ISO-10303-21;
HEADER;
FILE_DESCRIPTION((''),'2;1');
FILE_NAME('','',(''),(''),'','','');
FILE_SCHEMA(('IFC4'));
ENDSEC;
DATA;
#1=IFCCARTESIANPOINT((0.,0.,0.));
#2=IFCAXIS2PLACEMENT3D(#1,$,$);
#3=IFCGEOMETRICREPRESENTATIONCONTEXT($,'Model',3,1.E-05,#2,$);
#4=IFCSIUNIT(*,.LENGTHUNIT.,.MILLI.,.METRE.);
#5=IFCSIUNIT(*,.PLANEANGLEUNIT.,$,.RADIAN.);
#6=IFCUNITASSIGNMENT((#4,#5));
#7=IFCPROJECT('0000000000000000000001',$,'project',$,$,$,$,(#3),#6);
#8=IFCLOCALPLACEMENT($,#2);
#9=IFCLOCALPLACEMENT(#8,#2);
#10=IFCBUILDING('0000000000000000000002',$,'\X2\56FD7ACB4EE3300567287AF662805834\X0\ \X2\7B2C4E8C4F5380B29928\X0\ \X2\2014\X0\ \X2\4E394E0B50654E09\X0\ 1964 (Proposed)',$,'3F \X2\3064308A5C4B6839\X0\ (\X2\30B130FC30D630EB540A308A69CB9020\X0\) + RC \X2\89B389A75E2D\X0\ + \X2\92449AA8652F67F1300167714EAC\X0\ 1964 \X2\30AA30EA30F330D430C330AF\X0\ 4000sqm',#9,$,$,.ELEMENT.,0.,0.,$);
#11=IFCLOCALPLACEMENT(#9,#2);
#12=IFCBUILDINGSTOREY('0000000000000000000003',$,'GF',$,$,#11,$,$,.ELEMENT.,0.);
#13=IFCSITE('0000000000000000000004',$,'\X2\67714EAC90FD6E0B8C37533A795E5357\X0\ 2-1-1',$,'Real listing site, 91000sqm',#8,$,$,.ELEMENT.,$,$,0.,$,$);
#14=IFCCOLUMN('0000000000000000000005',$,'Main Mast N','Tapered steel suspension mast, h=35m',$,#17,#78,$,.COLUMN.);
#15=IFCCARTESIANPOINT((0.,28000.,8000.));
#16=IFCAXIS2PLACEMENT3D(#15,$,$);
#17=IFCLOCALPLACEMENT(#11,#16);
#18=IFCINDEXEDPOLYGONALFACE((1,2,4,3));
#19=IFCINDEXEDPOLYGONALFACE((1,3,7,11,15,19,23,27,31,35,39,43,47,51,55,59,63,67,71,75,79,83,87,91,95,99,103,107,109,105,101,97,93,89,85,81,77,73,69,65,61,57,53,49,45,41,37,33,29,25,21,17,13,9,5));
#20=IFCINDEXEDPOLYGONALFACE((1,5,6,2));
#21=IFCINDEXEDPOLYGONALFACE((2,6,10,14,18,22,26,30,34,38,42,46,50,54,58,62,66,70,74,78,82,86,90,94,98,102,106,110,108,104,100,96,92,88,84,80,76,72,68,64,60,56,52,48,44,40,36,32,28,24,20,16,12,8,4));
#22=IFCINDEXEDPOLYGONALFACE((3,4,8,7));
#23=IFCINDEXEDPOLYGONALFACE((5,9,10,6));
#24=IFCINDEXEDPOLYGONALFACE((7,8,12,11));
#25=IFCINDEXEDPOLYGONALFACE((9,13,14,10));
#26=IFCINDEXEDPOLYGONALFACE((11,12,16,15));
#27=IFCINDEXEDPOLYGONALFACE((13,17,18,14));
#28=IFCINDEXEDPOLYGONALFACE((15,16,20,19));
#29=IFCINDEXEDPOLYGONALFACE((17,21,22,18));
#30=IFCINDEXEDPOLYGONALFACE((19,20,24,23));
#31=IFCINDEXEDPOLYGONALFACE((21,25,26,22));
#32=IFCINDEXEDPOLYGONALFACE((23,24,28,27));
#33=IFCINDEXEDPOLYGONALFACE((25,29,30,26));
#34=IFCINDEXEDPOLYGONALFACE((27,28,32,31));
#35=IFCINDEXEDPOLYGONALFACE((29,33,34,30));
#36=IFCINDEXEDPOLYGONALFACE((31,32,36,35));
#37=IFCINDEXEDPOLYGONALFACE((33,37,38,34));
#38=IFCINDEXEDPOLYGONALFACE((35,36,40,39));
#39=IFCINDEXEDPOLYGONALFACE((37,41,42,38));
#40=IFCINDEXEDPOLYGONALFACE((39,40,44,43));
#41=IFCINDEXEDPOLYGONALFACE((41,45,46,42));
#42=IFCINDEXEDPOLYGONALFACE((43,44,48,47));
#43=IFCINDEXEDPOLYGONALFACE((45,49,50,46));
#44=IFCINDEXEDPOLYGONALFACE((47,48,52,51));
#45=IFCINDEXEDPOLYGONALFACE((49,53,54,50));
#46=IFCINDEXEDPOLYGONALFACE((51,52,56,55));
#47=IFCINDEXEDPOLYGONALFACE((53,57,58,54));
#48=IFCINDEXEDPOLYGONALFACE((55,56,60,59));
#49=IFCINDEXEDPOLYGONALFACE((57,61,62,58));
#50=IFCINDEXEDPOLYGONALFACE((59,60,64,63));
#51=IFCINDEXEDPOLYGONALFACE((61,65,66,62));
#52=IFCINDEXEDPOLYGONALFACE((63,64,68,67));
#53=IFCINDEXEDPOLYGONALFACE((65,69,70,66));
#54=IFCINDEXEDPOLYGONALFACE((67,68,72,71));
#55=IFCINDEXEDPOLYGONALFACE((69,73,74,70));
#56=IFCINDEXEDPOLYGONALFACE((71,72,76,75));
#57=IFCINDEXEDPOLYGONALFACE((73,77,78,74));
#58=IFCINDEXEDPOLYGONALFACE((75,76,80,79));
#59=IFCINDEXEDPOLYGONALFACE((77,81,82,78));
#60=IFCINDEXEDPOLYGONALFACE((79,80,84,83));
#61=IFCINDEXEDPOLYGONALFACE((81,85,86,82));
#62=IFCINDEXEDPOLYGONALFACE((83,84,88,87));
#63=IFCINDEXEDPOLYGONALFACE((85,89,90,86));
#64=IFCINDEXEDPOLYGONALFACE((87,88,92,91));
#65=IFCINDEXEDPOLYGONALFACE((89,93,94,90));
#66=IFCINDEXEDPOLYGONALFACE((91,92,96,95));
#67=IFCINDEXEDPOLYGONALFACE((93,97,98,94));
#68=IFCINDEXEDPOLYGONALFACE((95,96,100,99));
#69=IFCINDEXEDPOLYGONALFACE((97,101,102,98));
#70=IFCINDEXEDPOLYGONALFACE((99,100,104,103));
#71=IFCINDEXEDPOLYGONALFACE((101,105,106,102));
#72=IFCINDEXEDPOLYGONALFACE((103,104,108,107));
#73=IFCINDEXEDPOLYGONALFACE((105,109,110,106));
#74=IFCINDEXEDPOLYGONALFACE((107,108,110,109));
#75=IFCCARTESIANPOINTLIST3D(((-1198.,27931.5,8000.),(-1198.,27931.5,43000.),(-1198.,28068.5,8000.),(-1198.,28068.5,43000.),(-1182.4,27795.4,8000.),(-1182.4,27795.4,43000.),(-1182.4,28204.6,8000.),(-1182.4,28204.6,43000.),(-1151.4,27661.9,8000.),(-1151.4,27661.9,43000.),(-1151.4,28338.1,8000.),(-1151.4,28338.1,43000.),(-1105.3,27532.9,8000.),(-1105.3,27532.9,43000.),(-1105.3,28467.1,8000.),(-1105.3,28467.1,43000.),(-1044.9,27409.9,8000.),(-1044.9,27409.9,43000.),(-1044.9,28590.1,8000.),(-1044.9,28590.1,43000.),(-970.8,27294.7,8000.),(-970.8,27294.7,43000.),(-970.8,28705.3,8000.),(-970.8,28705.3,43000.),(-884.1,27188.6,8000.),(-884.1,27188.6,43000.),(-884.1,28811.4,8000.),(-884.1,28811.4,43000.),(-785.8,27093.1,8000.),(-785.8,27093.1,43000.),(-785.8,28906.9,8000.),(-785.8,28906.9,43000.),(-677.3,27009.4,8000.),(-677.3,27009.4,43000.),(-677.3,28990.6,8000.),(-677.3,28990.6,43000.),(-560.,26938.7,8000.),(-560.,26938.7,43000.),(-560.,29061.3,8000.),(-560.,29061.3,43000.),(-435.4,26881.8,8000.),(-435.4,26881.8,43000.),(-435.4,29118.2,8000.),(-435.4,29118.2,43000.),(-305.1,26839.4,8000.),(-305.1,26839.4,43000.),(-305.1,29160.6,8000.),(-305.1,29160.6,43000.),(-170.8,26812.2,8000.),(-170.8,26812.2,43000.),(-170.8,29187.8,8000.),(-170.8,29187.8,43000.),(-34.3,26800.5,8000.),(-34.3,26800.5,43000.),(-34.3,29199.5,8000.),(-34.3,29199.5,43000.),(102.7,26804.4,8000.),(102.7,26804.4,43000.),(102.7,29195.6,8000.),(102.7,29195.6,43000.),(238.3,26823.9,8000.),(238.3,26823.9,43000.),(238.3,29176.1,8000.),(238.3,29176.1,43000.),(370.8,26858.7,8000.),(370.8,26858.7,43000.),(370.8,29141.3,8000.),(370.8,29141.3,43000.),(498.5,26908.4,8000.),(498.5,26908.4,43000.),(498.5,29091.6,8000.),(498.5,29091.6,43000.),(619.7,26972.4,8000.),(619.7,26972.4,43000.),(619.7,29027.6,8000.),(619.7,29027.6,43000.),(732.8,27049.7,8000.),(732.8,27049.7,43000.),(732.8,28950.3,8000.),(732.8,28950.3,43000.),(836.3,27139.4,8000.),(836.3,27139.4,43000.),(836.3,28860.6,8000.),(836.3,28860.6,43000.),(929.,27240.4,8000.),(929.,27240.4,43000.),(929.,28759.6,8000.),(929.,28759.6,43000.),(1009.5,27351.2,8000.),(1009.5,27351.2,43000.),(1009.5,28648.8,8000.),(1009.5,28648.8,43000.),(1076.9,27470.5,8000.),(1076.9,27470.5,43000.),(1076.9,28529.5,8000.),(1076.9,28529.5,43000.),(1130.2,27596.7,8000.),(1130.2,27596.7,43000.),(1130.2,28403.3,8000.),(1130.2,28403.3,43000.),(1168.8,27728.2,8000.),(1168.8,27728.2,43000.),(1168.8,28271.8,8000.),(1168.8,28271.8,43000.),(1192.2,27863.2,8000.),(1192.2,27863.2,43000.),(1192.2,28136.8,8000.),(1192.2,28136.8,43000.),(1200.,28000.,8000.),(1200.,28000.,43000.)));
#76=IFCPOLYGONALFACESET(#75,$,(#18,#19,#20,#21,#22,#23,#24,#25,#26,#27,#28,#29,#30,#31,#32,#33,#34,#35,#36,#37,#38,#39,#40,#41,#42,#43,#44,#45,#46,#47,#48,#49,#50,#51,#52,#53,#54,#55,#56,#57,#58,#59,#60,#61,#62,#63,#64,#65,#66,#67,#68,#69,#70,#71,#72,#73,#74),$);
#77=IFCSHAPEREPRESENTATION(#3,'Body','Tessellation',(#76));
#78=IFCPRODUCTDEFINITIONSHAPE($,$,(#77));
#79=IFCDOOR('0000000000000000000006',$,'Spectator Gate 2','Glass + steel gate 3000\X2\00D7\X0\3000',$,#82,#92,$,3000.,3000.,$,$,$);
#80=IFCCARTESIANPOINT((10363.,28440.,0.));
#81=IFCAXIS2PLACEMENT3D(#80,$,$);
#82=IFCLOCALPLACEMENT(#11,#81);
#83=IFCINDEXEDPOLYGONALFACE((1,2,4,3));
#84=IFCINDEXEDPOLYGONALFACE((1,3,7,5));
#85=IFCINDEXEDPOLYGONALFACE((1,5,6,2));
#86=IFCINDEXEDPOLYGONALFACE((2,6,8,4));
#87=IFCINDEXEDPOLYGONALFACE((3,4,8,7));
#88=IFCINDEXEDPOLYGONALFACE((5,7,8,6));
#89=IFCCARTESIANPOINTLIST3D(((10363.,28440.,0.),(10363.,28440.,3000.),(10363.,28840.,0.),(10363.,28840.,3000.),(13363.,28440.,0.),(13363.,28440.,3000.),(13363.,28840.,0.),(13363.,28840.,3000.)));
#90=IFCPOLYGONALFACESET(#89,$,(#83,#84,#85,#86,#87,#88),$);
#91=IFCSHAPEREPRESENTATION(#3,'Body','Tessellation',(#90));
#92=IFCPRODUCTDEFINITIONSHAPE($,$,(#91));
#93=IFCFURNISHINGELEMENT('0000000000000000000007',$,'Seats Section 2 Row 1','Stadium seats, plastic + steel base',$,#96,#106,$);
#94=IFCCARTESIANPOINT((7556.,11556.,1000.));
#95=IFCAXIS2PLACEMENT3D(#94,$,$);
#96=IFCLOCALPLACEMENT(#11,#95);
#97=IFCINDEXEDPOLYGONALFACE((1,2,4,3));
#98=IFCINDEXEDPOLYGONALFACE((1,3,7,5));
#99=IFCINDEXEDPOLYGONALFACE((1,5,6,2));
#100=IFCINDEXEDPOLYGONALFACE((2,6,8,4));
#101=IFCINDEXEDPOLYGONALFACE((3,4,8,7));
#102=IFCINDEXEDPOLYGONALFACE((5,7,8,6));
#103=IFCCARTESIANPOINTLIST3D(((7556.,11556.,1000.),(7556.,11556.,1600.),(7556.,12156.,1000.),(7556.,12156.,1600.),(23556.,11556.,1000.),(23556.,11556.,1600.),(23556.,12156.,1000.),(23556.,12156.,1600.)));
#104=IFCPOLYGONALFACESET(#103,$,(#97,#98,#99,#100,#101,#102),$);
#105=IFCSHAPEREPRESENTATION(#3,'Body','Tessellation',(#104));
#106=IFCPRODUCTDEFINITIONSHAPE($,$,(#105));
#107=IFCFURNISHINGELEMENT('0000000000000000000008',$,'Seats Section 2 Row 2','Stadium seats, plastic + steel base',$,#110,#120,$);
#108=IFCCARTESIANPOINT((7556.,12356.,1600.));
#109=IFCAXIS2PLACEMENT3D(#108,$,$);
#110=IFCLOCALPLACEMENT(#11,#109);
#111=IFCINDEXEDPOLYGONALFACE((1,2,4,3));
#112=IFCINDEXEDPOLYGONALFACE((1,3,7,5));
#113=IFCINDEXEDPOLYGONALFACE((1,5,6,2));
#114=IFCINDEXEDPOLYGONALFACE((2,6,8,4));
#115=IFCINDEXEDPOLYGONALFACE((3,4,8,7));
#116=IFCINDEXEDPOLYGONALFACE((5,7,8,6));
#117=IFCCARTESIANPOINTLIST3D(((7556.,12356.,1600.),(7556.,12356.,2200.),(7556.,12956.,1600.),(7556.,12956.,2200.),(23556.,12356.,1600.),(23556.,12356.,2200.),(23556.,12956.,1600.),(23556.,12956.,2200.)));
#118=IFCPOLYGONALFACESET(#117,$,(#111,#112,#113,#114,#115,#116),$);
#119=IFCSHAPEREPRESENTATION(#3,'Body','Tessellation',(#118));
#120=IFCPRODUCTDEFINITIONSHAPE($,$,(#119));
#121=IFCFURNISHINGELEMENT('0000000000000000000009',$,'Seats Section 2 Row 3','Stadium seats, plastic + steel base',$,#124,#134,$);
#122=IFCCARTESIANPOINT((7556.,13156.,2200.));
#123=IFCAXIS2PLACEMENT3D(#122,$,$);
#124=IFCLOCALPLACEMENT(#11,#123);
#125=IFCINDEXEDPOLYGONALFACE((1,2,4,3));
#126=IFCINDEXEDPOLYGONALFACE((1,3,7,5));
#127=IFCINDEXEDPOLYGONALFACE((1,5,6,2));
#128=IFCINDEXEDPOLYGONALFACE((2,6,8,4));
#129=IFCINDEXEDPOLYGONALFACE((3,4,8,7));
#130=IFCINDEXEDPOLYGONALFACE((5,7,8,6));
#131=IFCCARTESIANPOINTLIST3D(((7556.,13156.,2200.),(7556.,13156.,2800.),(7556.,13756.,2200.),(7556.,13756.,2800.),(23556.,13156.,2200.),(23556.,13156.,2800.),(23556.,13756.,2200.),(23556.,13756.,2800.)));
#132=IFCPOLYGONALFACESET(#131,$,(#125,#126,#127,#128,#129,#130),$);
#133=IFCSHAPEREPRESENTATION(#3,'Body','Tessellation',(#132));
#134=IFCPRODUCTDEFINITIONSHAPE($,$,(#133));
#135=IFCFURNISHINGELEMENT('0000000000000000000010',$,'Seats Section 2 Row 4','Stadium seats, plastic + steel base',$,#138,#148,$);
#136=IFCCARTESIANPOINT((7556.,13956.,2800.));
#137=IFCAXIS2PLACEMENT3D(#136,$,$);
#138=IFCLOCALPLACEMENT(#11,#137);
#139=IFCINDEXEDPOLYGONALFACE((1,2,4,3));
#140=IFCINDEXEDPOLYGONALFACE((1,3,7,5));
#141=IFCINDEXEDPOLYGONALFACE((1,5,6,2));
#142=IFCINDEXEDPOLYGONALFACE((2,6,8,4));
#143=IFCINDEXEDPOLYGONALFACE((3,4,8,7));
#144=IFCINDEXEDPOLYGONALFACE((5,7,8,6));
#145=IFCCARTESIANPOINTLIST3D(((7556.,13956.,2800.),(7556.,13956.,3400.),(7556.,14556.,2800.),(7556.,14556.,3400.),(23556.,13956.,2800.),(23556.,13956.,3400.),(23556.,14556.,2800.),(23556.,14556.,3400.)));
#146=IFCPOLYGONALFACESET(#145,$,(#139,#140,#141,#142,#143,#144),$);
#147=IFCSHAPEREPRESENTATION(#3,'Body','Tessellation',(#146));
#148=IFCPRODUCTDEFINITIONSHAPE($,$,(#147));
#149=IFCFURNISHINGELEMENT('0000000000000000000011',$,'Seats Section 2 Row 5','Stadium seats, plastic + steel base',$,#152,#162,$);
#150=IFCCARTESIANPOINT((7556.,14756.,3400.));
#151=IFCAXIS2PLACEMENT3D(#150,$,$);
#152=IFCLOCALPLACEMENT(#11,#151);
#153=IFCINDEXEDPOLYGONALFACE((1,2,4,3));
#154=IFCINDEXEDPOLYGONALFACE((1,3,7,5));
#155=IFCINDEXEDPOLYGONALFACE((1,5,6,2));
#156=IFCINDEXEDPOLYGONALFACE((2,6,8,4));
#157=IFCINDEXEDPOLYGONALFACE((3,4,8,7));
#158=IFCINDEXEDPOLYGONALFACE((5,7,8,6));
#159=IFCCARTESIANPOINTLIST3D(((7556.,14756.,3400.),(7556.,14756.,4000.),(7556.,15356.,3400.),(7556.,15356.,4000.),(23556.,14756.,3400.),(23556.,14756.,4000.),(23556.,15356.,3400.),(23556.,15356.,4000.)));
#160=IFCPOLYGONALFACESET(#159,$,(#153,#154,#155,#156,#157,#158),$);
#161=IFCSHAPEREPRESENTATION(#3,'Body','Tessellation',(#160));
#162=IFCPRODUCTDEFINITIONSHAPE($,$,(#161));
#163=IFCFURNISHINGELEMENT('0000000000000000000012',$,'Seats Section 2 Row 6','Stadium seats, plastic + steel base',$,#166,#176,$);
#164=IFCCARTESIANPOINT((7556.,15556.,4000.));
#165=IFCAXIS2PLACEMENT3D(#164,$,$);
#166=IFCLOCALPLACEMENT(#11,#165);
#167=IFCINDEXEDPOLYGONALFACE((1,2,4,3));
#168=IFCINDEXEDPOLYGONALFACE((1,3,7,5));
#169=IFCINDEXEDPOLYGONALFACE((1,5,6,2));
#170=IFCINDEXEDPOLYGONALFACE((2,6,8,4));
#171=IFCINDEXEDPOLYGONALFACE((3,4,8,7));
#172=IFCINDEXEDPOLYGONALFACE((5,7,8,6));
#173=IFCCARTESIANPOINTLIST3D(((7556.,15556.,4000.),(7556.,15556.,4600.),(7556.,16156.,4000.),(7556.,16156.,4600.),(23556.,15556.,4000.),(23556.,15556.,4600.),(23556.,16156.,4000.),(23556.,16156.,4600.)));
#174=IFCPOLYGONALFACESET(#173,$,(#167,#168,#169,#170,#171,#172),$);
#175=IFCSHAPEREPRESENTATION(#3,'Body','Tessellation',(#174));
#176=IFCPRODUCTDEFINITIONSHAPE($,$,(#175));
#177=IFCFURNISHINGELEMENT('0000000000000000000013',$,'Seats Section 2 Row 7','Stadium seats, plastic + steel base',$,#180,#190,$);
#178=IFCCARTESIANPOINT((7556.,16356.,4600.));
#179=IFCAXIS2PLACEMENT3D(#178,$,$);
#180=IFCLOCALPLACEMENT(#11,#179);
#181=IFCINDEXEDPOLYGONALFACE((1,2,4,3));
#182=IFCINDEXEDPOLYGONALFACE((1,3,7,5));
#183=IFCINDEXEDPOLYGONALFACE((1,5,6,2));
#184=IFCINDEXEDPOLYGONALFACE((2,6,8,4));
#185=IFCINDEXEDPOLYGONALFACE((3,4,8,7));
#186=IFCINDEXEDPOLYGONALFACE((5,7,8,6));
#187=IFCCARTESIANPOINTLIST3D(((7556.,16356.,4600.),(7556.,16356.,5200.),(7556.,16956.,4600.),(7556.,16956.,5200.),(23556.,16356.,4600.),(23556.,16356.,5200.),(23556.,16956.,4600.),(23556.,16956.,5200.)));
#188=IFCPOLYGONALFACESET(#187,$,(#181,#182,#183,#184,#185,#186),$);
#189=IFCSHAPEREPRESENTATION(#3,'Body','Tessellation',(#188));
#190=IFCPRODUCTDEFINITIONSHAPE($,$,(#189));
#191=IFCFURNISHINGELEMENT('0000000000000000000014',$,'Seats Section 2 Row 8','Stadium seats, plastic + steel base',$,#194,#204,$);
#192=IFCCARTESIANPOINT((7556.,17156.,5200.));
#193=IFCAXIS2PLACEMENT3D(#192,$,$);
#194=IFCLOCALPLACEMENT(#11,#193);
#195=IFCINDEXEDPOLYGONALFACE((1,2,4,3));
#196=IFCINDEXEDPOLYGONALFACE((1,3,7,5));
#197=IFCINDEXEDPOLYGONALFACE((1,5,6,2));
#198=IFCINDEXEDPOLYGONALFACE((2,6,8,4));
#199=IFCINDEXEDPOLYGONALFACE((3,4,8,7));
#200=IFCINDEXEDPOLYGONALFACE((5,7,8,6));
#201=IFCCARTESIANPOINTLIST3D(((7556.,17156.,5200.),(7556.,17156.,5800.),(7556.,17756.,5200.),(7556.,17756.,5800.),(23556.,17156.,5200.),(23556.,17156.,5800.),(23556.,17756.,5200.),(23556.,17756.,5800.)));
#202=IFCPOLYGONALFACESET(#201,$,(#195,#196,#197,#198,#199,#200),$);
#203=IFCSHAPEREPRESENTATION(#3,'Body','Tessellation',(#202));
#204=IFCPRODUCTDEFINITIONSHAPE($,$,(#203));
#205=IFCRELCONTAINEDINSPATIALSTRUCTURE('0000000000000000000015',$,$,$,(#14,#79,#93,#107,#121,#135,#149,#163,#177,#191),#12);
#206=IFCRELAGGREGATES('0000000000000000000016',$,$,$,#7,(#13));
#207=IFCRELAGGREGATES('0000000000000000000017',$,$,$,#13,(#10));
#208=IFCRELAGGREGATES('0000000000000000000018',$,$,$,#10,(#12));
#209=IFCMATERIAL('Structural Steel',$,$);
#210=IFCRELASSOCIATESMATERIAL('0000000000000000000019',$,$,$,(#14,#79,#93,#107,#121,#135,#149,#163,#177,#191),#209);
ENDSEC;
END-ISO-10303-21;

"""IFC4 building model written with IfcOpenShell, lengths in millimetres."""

from ifc_helpers import new_model, si_unit, frame, frame_2d, origin, origin_2d, place, context, project, spatial, rectangle, circle, extrude, material, element, save


model = new_model("IFC4")

# Units and contexts
model_context = context("Model", 3, precision=1e-05, world=origin())
ifc_project = project(units=[si_unit("LENGTHUNIT", "METRE", prefix="MILLI"), si_unit("PLANEANGLEUNIT", "RADIAN")], contexts=[model_context])

# Site, building, storey
site_placement = place(None, origin())
site = spatial("IfcSite", under=ifc_project, at=site_placement, Name="東京都渋谷区神南 2-1-1", ObjectType="Real listing site, 91000sqm", CompositionType="ELEMENT", RefElevation=0.0)
building_placement = place(site_placement, origin())
building = spatial("IfcBuilding", under=site, at=building_placement, Name="国立代々木競技場 第二体育館 — 丹下健三 1964 (Proposed)", ObjectType="3F つり屋根 (ケーブル吊り構造) + RC 観覧席 + 鉄骨支柱、東京 1964 オリンピック 4000sqm", CompositionType="ELEMENT", ElevationOfRefHeight=0.0, ElevationOfTerrain=0.0)
storey_placement = place(building_placement, origin())
storey = spatial("IfcBuildingStorey", under=building, at=storey_placement, Name="GF", CompositionType="ELEMENT", Elevation=0.0)

# Column
ifc_material_1 = material(Name="Structural Steel")
column_placement = place(storey_placement, frame((0.0, 28000.0, 8000.0)))
element("IfcColumn", 1, at=column_placement, inside=storey, material=ifc_material_1, Name="Main Mast N", Description="Tapered steel suspension mast, h=35m", PredefinedType="COLUMN", context=model_context, shape_type="SweptSolid", body=[
    extrude(circle(Radius=1200.0, at=origin_2d()), frame((0.0, 28000.0, 8000.0)), (0.0, 0.0, 1.0), 35000.0),
])

# Door
door_placement = place(storey_placement, frame((10363.0, 28440.0, 0.0)))
element("IfcDoor", 2, at=door_placement, inside=storey, material=ifc_material_1, Name="Spectator Gate 2", Description="Glass + steel gate 3000×3000", OverallHeight=3000.0, OverallWidth=3000.0, context=model_context, shape_type="SweptSolid", body=[
    extrude(rectangle(XDim=3000.0, YDim=400.0, at=frame_2d((1500.0, 200.0))), frame((10363.0, 28440.0, 0.0)), (0.0, 0.0, 1.0), 3000.0),
])

# Furnishing elements
furnishing_1_placement = place(storey_placement, frame((7556.0, 11556.0, 1000.0)))
element("IfcFurnishingElement", 3, at=furnishing_1_placement, inside=storey, material=ifc_material_1, Name="Seats Section 2 Row 1", Description="Stadium seats, plastic + steel base", context=model_context, shape_type="SweptSolid", body=[
    extrude(rectangle(XDim=16000.0, YDim=600.0, at=frame_2d((8000.0, 300.0))), frame((7556.0, 11556.0, 1000.0)), (0.0, 0.0, 1.0), 600.0),
])
furnishing_2_placement = place(storey_placement, frame((7556.0, 12356.0, 1600.0)))
element("IfcFurnishingElement", 4, at=furnishing_2_placement, inside=storey, material=ifc_material_1, Name="Seats Section 2 Row 2", Description="Stadium seats, plastic + steel base", context=model_context, shape_type="SweptSolid", body=[
    extrude(rectangle(XDim=16000.0, YDim=600.0, at=frame_2d((8000.0, 300.0))), frame((7556.0, 12356.0, 1600.0)), (0.0, 0.0, 1.0), 600.0),
])
furnishing_3_placement = place(storey_placement, frame((7556.0, 13156.0, 2200.0)))
element("IfcFurnishingElement", 5, at=furnishing_3_placement, inside=storey, material=ifc_material_1, Name="Seats Section 2 Row 3", Description="Stadium seats, plastic + steel base", context=model_context, shape_type="SweptSolid", body=[
    extrude(rectangle(XDim=16000.0, YDim=600.0, at=frame_2d((8000.0, 300.0))), frame((7556.0, 13156.0, 2200.0)), (0.0, 0.0, 1.0), 600.0),
])
furnishing_4_placement = place(storey_placement, frame((7556.0, 13956.0, 2800.0)))
element("IfcFurnishingElement", 6, at=furnishing_4_placement, inside=storey, material=ifc_material_1, Name="Seats Section 2 Row 4", Description="Stadium seats, plastic + steel base", context=model_context, shape_type="SweptSolid", body=[
    extrude(rectangle(XDim=16000.0, YDim=600.0, at=frame_2d((8000.0, 300.0))), frame((7556.0, 13956.0, 2800.0)), (0.0, 0.0, 1.0), 600.0),
])
furnishing_5_placement = place(storey_placement, frame((7556.0, 14756.0, 3400.0)))
element("IfcFurnishingElement", 7, at=furnishing_5_placement, inside=storey, material=ifc_material_1, Name="Seats Section 2 Row 5", Description="Stadium seats, plastic + steel base", context=model_context, shape_type="SweptSolid", body=[
    extrude(rectangle(XDim=16000.0, YDim=600.0, at=frame_2d((8000.0, 300.0))), frame((7556.0, 14756.0, 3400.0)), (0.0, 0.0, 1.0), 600.0),
])
furnishing_6_placement = place(storey_placement, frame((7556.0, 15556.0, 4000.0)))
element("IfcFurnishingElement", 8, at=furnishing_6_placement, inside=storey, material=ifc_material_1, Name="Seats Section 2 Row 6", Description="Stadium seats, plastic + steel base", context=model_context, shape_type="SweptSolid", body=[
    extrude(rectangle(XDim=16000.0, YDim=600.0, at=frame_2d((8000.0, 300.0))), frame((7556.0, 15556.0, 4000.0)), (0.0, 0.0, 1.0), 600.0),
])
furnishing_7_placement = place(storey_placement, frame((7556.0, 16356.0, 4600.0)))
element("IfcFurnishingElement", 9, at=furnishing_7_placement, inside=storey, material=ifc_material_1, Name="Seats Section 2 Row 7", Description="Stadium seats, plastic + steel base", context=model_context, shape_type="SweptSolid", body=[
    extrude(rectangle(XDim=16000.0, YDim=600.0, at=frame_2d((8000.0, 300.0))), frame((7556.0, 16356.0, 4600.0)), (0.0, 0.0, 1.0), 600.0),
])
furnishing_8_placement = place(storey_placement, frame((7556.0, 17156.0, 5200.0)))
element("IfcFurnishingElement", 10, at=furnishing_8_placement, inside=storey, material=ifc_material_1, Name="Seats Section 2 Row 8", Description="Stadium seats, plastic + steel base", context=model_context, shape_type="SweptSolid", body=[
    extrude(rectangle(XDim=16000.0, YDim=600.0, at=frame_2d((8000.0, 300.0))), frame((7556.0, 17156.0, 5200.0)), (0.0, 0.0, 1.0), 600.0),
])

save(model, "model.ifc")
